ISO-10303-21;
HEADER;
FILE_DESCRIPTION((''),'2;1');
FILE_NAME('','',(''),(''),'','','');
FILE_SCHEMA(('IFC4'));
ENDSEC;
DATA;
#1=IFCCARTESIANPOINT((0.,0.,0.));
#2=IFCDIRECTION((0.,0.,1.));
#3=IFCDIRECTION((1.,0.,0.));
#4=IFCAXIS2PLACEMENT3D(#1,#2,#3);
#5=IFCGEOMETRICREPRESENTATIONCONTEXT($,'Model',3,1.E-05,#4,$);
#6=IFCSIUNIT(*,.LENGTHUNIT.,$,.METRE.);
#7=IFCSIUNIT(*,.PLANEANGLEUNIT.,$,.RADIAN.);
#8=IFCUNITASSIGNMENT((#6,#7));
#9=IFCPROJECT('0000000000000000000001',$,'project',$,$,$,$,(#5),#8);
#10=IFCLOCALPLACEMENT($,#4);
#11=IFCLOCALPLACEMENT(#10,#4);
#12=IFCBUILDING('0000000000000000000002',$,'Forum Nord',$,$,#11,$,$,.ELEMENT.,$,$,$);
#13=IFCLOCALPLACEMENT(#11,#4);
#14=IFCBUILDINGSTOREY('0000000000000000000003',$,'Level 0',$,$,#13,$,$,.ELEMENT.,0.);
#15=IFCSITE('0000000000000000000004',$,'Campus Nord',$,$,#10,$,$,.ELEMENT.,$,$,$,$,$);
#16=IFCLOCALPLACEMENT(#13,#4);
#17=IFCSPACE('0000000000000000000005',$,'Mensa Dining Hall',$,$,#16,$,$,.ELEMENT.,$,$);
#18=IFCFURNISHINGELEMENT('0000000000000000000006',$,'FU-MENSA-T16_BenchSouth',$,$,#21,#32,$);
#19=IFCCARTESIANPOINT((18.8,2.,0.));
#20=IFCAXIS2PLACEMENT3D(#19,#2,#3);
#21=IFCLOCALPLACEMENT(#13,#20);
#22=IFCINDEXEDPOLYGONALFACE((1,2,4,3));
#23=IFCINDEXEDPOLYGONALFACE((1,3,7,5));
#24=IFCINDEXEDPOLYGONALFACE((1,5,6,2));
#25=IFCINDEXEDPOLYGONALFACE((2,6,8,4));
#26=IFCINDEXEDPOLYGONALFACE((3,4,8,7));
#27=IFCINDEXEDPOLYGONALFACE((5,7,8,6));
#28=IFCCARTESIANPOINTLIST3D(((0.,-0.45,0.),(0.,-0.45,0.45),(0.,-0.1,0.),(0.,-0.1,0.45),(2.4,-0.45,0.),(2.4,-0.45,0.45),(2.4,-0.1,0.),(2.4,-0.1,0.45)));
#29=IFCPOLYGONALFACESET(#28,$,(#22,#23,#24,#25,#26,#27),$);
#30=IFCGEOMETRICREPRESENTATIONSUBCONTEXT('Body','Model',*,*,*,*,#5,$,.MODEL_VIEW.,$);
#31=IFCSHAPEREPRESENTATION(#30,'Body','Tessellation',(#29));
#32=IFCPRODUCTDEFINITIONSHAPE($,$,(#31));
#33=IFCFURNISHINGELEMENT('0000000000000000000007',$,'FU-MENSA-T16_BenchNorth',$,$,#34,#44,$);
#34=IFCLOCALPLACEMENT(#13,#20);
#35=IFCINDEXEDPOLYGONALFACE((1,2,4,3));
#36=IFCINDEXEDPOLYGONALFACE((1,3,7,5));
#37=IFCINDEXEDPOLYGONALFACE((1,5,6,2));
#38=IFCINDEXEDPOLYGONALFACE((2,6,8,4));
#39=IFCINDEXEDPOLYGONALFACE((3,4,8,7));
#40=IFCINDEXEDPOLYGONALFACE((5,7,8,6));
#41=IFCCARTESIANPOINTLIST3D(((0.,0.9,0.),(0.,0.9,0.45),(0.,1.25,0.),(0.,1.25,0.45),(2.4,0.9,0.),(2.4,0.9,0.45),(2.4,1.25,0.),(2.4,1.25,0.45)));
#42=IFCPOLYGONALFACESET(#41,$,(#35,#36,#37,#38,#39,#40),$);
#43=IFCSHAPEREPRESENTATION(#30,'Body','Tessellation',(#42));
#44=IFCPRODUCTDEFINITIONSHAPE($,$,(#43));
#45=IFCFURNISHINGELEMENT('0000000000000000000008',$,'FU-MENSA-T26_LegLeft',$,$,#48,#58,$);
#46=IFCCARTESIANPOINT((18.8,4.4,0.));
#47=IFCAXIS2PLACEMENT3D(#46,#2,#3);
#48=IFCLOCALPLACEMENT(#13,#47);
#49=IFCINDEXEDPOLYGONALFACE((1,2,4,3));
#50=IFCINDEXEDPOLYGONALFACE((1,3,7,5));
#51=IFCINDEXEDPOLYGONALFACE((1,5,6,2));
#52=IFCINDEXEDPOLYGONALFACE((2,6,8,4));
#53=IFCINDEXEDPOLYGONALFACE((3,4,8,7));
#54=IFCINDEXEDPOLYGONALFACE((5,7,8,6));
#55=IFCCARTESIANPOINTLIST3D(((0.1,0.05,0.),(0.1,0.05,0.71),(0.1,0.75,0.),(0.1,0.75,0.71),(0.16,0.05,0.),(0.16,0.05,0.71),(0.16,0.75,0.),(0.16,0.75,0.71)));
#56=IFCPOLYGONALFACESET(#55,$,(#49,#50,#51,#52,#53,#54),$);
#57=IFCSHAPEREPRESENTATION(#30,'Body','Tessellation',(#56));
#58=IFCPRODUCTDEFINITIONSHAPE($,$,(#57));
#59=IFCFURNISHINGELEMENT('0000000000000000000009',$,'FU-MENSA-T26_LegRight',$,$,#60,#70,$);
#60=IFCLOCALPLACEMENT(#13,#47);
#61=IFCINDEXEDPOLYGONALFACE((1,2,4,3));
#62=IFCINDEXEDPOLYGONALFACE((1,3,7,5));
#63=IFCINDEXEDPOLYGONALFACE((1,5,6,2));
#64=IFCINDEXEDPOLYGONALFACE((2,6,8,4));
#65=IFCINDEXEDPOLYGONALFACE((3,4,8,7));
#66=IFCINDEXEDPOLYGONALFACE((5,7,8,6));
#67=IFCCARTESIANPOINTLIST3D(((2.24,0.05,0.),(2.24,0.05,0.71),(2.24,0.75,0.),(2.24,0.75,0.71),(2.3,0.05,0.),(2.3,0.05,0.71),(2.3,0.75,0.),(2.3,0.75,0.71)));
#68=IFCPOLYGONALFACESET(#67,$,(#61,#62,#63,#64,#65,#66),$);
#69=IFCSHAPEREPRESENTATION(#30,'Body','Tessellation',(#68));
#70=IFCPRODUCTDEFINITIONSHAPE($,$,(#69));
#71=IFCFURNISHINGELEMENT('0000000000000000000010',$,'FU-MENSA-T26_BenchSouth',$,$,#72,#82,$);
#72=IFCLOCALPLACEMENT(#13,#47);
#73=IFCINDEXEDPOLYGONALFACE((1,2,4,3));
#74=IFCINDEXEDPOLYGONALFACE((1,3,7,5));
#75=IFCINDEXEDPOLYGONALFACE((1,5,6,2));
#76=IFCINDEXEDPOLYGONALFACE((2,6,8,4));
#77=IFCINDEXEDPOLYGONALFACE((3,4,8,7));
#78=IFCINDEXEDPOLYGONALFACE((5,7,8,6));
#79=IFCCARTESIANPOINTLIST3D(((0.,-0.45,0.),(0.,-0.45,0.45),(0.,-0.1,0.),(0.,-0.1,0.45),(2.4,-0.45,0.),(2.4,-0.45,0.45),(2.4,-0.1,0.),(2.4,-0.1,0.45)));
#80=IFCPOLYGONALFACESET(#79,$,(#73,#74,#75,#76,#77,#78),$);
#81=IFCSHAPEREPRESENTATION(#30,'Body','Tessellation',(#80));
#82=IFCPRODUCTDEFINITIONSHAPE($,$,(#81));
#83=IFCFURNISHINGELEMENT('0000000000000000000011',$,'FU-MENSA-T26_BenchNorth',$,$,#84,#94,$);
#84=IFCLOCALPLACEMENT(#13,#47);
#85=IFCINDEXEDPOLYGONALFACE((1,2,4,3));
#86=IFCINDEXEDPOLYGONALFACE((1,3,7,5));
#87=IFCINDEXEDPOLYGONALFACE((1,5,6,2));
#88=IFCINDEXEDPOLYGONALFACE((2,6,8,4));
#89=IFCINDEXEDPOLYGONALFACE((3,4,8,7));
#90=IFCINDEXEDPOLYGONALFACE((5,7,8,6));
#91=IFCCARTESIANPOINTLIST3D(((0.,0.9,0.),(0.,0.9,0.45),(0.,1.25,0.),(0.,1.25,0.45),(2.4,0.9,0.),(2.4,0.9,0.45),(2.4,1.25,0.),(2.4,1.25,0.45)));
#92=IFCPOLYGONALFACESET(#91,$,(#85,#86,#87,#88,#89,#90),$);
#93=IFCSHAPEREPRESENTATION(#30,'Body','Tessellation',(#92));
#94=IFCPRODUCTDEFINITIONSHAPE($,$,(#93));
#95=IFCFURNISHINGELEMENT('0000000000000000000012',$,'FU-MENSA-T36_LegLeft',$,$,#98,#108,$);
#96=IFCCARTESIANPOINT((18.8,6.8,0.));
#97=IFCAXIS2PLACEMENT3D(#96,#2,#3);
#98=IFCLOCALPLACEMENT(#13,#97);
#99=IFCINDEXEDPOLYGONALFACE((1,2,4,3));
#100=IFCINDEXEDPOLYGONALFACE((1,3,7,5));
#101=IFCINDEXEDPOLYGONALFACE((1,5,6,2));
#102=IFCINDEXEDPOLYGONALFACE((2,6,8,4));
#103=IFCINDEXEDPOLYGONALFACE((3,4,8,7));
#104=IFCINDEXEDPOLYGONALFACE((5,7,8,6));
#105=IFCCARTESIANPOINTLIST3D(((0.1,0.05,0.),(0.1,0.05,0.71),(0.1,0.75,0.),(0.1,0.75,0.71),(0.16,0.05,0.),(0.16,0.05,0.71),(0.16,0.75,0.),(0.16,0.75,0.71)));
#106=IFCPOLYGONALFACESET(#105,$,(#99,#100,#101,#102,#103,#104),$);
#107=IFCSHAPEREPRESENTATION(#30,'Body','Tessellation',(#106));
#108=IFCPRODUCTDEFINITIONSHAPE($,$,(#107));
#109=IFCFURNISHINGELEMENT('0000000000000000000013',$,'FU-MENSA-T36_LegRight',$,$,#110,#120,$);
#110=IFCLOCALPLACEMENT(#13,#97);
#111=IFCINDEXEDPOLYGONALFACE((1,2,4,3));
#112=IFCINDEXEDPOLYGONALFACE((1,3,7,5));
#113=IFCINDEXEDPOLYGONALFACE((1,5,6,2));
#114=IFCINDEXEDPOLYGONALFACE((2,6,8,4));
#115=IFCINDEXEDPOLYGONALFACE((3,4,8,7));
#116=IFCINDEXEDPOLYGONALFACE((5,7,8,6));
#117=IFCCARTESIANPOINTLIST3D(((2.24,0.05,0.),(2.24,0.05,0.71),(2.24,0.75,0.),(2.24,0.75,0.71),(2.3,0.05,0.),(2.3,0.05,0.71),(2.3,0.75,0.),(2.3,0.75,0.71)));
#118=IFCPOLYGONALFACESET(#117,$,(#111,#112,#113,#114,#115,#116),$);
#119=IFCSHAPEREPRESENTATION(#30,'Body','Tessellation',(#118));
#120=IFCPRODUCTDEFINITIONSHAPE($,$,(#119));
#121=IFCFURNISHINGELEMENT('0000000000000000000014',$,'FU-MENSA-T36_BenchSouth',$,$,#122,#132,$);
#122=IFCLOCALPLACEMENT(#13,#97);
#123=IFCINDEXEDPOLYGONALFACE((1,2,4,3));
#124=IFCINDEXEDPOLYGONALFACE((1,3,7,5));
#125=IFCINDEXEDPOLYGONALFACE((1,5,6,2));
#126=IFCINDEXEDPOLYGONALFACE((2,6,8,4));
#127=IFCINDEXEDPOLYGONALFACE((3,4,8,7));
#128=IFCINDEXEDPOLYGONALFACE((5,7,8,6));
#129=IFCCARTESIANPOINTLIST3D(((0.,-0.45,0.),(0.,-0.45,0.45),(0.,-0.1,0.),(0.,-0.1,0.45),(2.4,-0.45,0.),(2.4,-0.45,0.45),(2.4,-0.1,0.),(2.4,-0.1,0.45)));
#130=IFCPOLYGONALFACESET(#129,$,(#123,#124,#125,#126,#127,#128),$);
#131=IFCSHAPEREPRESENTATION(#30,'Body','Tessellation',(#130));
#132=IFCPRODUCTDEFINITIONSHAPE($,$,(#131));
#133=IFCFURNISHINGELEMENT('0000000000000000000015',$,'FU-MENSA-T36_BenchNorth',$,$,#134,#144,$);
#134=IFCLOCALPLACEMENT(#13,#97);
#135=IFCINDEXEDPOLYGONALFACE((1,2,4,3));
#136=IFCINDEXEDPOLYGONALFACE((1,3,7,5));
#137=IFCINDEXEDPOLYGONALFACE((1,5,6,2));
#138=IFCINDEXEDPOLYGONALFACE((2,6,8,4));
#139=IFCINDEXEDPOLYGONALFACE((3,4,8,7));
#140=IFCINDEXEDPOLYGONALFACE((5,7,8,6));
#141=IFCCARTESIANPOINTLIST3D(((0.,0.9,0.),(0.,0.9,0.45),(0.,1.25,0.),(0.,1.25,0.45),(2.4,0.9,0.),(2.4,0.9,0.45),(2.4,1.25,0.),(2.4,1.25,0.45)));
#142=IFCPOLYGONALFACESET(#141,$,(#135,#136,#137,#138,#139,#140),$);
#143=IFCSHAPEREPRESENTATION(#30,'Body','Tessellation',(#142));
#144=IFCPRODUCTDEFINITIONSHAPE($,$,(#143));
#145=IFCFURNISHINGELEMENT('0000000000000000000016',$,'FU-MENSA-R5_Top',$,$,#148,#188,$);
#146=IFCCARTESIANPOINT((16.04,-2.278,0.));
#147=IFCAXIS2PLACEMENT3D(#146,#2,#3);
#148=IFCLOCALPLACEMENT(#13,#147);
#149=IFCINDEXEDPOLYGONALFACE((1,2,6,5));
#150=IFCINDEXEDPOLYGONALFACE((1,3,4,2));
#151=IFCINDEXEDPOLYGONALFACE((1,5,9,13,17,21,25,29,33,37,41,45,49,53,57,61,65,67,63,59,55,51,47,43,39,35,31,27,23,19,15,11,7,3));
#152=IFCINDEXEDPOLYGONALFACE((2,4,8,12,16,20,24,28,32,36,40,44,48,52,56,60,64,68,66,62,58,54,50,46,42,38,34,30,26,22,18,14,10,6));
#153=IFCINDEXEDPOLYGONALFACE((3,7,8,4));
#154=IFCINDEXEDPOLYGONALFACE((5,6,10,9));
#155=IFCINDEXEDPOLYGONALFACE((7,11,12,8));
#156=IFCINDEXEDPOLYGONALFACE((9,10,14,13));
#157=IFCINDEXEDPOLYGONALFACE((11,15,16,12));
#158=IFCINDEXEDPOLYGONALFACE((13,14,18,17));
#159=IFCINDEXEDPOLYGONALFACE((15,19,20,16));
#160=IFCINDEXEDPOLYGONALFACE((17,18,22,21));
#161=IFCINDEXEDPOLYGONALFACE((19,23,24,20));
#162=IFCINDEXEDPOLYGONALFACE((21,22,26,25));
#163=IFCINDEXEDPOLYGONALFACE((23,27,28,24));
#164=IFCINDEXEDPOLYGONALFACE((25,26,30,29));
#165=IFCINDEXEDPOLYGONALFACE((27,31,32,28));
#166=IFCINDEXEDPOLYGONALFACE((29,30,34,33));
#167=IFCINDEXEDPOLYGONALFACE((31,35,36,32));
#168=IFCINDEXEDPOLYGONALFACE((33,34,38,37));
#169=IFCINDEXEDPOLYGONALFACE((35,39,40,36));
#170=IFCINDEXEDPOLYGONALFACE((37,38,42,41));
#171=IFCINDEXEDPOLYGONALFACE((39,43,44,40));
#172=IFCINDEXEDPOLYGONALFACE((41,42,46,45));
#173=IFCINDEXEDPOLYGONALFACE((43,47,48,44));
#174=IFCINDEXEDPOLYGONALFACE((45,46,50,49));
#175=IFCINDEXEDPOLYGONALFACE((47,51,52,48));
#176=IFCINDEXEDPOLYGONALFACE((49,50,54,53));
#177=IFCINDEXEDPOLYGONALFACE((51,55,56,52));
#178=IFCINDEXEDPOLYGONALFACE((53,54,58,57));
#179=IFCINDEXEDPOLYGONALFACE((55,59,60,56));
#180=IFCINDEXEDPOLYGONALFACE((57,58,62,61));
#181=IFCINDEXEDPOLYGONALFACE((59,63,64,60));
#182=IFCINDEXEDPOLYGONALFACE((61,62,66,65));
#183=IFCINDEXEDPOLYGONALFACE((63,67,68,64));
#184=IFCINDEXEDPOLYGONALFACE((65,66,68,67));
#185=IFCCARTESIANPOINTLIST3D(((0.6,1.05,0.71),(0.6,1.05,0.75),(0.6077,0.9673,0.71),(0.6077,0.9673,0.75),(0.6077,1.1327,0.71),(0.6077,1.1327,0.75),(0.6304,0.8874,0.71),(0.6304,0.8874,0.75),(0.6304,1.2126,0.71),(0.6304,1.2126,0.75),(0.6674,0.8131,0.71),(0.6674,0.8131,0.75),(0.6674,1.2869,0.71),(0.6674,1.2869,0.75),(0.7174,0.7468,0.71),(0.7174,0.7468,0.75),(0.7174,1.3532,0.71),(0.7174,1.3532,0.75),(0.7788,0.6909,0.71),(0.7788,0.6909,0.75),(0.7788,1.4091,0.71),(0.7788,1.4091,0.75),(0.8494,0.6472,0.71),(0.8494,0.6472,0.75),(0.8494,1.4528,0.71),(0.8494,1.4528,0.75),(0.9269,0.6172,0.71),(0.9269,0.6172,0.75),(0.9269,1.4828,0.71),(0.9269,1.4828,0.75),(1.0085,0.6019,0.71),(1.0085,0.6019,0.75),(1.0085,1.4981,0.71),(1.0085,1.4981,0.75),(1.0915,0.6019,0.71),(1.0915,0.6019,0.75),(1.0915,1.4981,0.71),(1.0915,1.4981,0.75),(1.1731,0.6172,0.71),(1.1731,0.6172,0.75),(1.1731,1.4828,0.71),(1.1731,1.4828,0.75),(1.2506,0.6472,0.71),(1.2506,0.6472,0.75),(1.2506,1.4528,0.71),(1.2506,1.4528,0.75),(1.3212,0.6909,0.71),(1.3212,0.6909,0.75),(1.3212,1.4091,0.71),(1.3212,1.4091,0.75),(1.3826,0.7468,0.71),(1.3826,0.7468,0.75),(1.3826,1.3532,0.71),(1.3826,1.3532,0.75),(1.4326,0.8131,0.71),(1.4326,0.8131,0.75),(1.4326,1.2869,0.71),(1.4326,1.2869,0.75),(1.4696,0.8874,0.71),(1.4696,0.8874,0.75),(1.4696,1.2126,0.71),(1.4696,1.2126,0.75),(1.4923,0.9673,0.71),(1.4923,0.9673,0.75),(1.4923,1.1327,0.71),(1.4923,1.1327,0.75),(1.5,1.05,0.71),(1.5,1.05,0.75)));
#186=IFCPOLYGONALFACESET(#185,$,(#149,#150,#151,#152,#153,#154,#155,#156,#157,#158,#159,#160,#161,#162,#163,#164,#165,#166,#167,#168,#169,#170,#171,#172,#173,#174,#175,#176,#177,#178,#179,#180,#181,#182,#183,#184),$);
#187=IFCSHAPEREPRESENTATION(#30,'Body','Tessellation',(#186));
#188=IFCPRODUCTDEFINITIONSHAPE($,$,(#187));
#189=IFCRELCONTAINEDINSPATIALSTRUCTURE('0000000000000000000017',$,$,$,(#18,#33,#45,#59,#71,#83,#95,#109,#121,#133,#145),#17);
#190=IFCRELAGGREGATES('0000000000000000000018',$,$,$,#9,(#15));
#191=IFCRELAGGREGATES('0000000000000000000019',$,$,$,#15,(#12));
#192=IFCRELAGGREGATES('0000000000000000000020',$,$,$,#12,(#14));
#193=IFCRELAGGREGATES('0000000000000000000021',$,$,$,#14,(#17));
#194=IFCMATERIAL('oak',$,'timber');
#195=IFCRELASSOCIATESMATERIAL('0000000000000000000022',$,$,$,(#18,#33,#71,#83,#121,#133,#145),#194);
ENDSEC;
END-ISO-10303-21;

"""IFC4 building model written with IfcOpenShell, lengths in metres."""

from ifc_helpers import new_model, si_unit, frame, frame_2d, origin_with_axes, place, context, subcontext, project, spatial, rectangle, circle, extrude, material, element, save


model = new_model("IFC4")

# Units and contexts
model_context = context("Model", 3, precision=1e-05, world=origin_with_axes())
body_context = subcontext(model_context, "Body", "Model", "MODEL_VIEW")
ifc_project = project(units=[si_unit("LENGTHUNIT", "METRE"), si_unit("PLANEANGLEUNIT", "RADIAN")], contexts=[model_context])

# Site, building, storey, space
site_placement = place(None, origin_with_axes())
site = spatial("IfcSite", under=ifc_project, at=site_placement, Name="Campus Nord", CompositionType="ELEMENT")
building_placement = place(site_placement, origin_with_axes())
building = spatial("IfcBuilding", under=site, at=building_placement, Name="Forum Nord", CompositionType="ELEMENT")
storey_placement = place(building_placement, origin_with_axes())
storey = spatial("IfcBuildingStorey", under=building, at=storey_placement, Name="Level 0", CompositionType="ELEMENT", Elevation=0.0)
space_placement = place(storey_placement, origin_with_axes())
space = spatial("IfcSpace", under=storey, at=space_placement, Name="Mensa Dining Hall", CompositionType="ELEMENT")

# Furnishing elements
ifc_material_1 = material(Name="oak", Category="timber")
furnishing_1_placement = place(storey_placement, frame((18.8, 2.0, 0.0), z_axis=(0.0, 0.0, 1.0), x_axis=(1.0, 0.0, 0.0)))
element("IfcFurnishingElement", 1, at=furnishing_1_placement, inside=space, material=ifc_material_1, Name="FU-MENSA-T16_BenchSouth", context=body_context, shape_type="SweptSolid", body=[
    extrude(rectangle(XDim=2.4, YDim=0.35, at=frame_2d((1.2, -0.275), x_axis=(1.0, 0.0))), origin_with_axes(), (0.0, 0.0, 1.0), 0.45),
])
furnishing_2_placement = place(storey_placement, frame((18.8, 2.0, 0.0), z_axis=(0.0, 0.0, 1.0), x_axis=(1.0, 0.0, 0.0)))
element("IfcFurnishingElement", 2, at=furnishing_2_placement, inside=space, material=ifc_material_1, Name="FU-MENSA-T16_BenchNorth", context=body_context, shape_type="SweptSolid", body=[
    extrude(rectangle(XDim=2.4, YDim=0.35, at=frame_2d((1.2, 1.075), x_axis=(1.0, 0.0))), origin_with_axes(), (0.0, 0.0, 1.0), 0.45),
])
furnishing_3_placement = place(storey_placement, frame((18.8, 4.4, 0.0), z_axis=(0.0, 0.0, 1.0), x_axis=(1.0, 0.0, 0.0)))
element("IfcFurnishingElement", 3, at=furnishing_3_placement, inside=space, Name="FU-MENSA-T26_LegLeft", context=body_context, shape_type="SweptSolid", body=[
    extrude(rectangle(XDim=0.06, YDim=0.7, at=frame_2d((0.13, 0.4), x_axis=(1.0, 0.0))), origin_with_axes(), (0.0, 0.0, 1.0), 0.71),
])
furnishing_4_placement = place(storey_placement, frame((18.8, 4.4, 0.0), z_axis=(0.0, 0.0, 1.0), x_axis=(1.0, 0.0, 0.0)))
element("IfcFurnishingElement", 4, at=furnishing_4_placement, inside=space, Name="FU-MENSA-T26_LegRight", context=body_context, shape_type="SweptSolid", body=[
    extrude(rectangle(XDim=0.06, YDim=0.7, at=frame_2d((2.27, 0.4), x_axis=(1.0, 0.0))), origin_with_axes(), (0.0, 0.0, 1.0), 0.71),
])
furnishing_5_placement = place(storey_placement, frame((18.8, 4.4, 0.0), z_axis=(0.0, 0.0, 1.0), x_axis=(1.0, 0.0, 0.0)))
element("IfcFurnishingElement", 5, at=furnishing_5_placement, inside=space, material=ifc_material_1, Name="FU-MENSA-T26_BenchSouth", context=body_context, shape_type="SweptSolid", body=[
    extrude(rectangle(XDim=2.4, YDim=0.35, at=frame_2d((1.2, -0.275), x_axis=(1.0, 0.0))), origin_with_axes(), (0.0, 0.0, 1.0), 0.45),
])
furnishing_6_placement = place(storey_placement, frame((18.8, 4.4, 0.0), z_axis=(0.0, 0.0, 1.0), x_axis=(1.0, 0.0, 0.0)))
element("IfcFurnishingElement", 6, at=furnishing_6_placement, inside=space, material=ifc_material_1, Name="FU-MENSA-T26_BenchNorth", context=body_context, shape_type="SweptSolid", body=[
    extrude(rectangle(XDim=2.4, YDim=0.35, at=frame_2d((1.2, 1.075), x_axis=(1.0, 0.0))), origin_with_axes(), (0.0, 0.0, 1.0), 0.45),
])
furnishing_7_placement = place(storey_placement, frame((18.8, 6.8, 0.0), z_axis=(0.0, 0.0, 1.0), x_axis=(1.0, 0.0, 0.0)))
element("IfcFurnishingElement", 7, at=furnishing_7_placement, inside=space, Name="FU-MENSA-T36_LegLeft", context=body_context, shape_type="SweptSolid", body=[
    extrude(rectangle(XDim=0.06, YDim=0.7, at=frame_2d((0.13, 0.4), x_axis=(1.0, 0.0))), origin_with_axes(), (0.0, 0.0, 1.0), 0.71),
])
furnishing_8_placement = place(storey_placement, frame((18.8, 6.8, 0.0), z_axis=(0.0, 0.0, 1.0), x_axis=(1.0, 0.0, 0.0)))
element("IfcFurnishingElement", 8, at=furnishing_8_placement, inside=space, Name="FU-MENSA-T36_LegRight", context=body_context, shape_type="SweptSolid", body=[
    extrude(rectangle(XDim=0.06, YDim=0.7, at=frame_2d((2.27, 0.4), x_axis=(1.0, 0.0))), origin_with_axes(), (0.0, 0.0, 1.0), 0.71),
])
furnishing_9_placement = place(storey_placement, frame((18.8, 6.8, 0.0), z_axis=(0.0, 0.0, 1.0), x_axis=(1.0, 0.0, 0.0)))
element("IfcFurnishingElement", 9, at=furnishing_9_placement, inside=space, material=ifc_material_1, Name="FU-MENSA-T36_BenchSouth", context=body_context, shape_type="SweptSolid", body=[
    extrude(rectangle(XDim=2.4, YDim=0.35, at=frame_2d((1.2, -0.275), x_axis=(1.0, 0.0))), origin_with_axes(), (0.0, 0.0, 1.0), 0.45),
])
furnishing_10_placement = place(storey_placement, frame((18.8, 6.8, 0.0), z_axis=(0.0, 0.0, 1.0), x_axis=(1.0, 0.0, 0.0)))
element("IfcFurnishingElement", 10, at=furnishing_10_placement, inside=space, material=ifc_material_1, Name="FU-MENSA-T36_BenchNorth", context=body_context, shape_type="SweptSolid", body=[
    extrude(rectangle(XDim=2.4, YDim=0.35, at=frame_2d((1.2, 1.075), x_axis=(1.0, 0.0))), origin_with_axes(), (0.0, 0.0, 1.0), 0.45),
])
furnishing_11_placement = place(storey_placement, frame((16.04, -2.278, 0.0), z_axis=(0.0, 0.0, 1.0), x_axis=(1.0, 0.0, 0.0)))
element("IfcFurnishingElement", 11, at=furnishing_11_placement, inside=space, material=ifc_material_1, Name="FU-MENSA-R5_Top", context=body_context, shape_type="SweptSolid", body=[
    extrude(circle(Radius=0.45, at=frame_2d((1.05, 1.05), x_axis=(1.0, 0.0))), frame((0.0, 0.0, 0.71), z_axis=(0.0, 0.0, 1.0), x_axis=(1.0, 0.0, 0.0)), (0.0, 0.0, 1.0), 0.04),
])

save(model, "model.ifc")
